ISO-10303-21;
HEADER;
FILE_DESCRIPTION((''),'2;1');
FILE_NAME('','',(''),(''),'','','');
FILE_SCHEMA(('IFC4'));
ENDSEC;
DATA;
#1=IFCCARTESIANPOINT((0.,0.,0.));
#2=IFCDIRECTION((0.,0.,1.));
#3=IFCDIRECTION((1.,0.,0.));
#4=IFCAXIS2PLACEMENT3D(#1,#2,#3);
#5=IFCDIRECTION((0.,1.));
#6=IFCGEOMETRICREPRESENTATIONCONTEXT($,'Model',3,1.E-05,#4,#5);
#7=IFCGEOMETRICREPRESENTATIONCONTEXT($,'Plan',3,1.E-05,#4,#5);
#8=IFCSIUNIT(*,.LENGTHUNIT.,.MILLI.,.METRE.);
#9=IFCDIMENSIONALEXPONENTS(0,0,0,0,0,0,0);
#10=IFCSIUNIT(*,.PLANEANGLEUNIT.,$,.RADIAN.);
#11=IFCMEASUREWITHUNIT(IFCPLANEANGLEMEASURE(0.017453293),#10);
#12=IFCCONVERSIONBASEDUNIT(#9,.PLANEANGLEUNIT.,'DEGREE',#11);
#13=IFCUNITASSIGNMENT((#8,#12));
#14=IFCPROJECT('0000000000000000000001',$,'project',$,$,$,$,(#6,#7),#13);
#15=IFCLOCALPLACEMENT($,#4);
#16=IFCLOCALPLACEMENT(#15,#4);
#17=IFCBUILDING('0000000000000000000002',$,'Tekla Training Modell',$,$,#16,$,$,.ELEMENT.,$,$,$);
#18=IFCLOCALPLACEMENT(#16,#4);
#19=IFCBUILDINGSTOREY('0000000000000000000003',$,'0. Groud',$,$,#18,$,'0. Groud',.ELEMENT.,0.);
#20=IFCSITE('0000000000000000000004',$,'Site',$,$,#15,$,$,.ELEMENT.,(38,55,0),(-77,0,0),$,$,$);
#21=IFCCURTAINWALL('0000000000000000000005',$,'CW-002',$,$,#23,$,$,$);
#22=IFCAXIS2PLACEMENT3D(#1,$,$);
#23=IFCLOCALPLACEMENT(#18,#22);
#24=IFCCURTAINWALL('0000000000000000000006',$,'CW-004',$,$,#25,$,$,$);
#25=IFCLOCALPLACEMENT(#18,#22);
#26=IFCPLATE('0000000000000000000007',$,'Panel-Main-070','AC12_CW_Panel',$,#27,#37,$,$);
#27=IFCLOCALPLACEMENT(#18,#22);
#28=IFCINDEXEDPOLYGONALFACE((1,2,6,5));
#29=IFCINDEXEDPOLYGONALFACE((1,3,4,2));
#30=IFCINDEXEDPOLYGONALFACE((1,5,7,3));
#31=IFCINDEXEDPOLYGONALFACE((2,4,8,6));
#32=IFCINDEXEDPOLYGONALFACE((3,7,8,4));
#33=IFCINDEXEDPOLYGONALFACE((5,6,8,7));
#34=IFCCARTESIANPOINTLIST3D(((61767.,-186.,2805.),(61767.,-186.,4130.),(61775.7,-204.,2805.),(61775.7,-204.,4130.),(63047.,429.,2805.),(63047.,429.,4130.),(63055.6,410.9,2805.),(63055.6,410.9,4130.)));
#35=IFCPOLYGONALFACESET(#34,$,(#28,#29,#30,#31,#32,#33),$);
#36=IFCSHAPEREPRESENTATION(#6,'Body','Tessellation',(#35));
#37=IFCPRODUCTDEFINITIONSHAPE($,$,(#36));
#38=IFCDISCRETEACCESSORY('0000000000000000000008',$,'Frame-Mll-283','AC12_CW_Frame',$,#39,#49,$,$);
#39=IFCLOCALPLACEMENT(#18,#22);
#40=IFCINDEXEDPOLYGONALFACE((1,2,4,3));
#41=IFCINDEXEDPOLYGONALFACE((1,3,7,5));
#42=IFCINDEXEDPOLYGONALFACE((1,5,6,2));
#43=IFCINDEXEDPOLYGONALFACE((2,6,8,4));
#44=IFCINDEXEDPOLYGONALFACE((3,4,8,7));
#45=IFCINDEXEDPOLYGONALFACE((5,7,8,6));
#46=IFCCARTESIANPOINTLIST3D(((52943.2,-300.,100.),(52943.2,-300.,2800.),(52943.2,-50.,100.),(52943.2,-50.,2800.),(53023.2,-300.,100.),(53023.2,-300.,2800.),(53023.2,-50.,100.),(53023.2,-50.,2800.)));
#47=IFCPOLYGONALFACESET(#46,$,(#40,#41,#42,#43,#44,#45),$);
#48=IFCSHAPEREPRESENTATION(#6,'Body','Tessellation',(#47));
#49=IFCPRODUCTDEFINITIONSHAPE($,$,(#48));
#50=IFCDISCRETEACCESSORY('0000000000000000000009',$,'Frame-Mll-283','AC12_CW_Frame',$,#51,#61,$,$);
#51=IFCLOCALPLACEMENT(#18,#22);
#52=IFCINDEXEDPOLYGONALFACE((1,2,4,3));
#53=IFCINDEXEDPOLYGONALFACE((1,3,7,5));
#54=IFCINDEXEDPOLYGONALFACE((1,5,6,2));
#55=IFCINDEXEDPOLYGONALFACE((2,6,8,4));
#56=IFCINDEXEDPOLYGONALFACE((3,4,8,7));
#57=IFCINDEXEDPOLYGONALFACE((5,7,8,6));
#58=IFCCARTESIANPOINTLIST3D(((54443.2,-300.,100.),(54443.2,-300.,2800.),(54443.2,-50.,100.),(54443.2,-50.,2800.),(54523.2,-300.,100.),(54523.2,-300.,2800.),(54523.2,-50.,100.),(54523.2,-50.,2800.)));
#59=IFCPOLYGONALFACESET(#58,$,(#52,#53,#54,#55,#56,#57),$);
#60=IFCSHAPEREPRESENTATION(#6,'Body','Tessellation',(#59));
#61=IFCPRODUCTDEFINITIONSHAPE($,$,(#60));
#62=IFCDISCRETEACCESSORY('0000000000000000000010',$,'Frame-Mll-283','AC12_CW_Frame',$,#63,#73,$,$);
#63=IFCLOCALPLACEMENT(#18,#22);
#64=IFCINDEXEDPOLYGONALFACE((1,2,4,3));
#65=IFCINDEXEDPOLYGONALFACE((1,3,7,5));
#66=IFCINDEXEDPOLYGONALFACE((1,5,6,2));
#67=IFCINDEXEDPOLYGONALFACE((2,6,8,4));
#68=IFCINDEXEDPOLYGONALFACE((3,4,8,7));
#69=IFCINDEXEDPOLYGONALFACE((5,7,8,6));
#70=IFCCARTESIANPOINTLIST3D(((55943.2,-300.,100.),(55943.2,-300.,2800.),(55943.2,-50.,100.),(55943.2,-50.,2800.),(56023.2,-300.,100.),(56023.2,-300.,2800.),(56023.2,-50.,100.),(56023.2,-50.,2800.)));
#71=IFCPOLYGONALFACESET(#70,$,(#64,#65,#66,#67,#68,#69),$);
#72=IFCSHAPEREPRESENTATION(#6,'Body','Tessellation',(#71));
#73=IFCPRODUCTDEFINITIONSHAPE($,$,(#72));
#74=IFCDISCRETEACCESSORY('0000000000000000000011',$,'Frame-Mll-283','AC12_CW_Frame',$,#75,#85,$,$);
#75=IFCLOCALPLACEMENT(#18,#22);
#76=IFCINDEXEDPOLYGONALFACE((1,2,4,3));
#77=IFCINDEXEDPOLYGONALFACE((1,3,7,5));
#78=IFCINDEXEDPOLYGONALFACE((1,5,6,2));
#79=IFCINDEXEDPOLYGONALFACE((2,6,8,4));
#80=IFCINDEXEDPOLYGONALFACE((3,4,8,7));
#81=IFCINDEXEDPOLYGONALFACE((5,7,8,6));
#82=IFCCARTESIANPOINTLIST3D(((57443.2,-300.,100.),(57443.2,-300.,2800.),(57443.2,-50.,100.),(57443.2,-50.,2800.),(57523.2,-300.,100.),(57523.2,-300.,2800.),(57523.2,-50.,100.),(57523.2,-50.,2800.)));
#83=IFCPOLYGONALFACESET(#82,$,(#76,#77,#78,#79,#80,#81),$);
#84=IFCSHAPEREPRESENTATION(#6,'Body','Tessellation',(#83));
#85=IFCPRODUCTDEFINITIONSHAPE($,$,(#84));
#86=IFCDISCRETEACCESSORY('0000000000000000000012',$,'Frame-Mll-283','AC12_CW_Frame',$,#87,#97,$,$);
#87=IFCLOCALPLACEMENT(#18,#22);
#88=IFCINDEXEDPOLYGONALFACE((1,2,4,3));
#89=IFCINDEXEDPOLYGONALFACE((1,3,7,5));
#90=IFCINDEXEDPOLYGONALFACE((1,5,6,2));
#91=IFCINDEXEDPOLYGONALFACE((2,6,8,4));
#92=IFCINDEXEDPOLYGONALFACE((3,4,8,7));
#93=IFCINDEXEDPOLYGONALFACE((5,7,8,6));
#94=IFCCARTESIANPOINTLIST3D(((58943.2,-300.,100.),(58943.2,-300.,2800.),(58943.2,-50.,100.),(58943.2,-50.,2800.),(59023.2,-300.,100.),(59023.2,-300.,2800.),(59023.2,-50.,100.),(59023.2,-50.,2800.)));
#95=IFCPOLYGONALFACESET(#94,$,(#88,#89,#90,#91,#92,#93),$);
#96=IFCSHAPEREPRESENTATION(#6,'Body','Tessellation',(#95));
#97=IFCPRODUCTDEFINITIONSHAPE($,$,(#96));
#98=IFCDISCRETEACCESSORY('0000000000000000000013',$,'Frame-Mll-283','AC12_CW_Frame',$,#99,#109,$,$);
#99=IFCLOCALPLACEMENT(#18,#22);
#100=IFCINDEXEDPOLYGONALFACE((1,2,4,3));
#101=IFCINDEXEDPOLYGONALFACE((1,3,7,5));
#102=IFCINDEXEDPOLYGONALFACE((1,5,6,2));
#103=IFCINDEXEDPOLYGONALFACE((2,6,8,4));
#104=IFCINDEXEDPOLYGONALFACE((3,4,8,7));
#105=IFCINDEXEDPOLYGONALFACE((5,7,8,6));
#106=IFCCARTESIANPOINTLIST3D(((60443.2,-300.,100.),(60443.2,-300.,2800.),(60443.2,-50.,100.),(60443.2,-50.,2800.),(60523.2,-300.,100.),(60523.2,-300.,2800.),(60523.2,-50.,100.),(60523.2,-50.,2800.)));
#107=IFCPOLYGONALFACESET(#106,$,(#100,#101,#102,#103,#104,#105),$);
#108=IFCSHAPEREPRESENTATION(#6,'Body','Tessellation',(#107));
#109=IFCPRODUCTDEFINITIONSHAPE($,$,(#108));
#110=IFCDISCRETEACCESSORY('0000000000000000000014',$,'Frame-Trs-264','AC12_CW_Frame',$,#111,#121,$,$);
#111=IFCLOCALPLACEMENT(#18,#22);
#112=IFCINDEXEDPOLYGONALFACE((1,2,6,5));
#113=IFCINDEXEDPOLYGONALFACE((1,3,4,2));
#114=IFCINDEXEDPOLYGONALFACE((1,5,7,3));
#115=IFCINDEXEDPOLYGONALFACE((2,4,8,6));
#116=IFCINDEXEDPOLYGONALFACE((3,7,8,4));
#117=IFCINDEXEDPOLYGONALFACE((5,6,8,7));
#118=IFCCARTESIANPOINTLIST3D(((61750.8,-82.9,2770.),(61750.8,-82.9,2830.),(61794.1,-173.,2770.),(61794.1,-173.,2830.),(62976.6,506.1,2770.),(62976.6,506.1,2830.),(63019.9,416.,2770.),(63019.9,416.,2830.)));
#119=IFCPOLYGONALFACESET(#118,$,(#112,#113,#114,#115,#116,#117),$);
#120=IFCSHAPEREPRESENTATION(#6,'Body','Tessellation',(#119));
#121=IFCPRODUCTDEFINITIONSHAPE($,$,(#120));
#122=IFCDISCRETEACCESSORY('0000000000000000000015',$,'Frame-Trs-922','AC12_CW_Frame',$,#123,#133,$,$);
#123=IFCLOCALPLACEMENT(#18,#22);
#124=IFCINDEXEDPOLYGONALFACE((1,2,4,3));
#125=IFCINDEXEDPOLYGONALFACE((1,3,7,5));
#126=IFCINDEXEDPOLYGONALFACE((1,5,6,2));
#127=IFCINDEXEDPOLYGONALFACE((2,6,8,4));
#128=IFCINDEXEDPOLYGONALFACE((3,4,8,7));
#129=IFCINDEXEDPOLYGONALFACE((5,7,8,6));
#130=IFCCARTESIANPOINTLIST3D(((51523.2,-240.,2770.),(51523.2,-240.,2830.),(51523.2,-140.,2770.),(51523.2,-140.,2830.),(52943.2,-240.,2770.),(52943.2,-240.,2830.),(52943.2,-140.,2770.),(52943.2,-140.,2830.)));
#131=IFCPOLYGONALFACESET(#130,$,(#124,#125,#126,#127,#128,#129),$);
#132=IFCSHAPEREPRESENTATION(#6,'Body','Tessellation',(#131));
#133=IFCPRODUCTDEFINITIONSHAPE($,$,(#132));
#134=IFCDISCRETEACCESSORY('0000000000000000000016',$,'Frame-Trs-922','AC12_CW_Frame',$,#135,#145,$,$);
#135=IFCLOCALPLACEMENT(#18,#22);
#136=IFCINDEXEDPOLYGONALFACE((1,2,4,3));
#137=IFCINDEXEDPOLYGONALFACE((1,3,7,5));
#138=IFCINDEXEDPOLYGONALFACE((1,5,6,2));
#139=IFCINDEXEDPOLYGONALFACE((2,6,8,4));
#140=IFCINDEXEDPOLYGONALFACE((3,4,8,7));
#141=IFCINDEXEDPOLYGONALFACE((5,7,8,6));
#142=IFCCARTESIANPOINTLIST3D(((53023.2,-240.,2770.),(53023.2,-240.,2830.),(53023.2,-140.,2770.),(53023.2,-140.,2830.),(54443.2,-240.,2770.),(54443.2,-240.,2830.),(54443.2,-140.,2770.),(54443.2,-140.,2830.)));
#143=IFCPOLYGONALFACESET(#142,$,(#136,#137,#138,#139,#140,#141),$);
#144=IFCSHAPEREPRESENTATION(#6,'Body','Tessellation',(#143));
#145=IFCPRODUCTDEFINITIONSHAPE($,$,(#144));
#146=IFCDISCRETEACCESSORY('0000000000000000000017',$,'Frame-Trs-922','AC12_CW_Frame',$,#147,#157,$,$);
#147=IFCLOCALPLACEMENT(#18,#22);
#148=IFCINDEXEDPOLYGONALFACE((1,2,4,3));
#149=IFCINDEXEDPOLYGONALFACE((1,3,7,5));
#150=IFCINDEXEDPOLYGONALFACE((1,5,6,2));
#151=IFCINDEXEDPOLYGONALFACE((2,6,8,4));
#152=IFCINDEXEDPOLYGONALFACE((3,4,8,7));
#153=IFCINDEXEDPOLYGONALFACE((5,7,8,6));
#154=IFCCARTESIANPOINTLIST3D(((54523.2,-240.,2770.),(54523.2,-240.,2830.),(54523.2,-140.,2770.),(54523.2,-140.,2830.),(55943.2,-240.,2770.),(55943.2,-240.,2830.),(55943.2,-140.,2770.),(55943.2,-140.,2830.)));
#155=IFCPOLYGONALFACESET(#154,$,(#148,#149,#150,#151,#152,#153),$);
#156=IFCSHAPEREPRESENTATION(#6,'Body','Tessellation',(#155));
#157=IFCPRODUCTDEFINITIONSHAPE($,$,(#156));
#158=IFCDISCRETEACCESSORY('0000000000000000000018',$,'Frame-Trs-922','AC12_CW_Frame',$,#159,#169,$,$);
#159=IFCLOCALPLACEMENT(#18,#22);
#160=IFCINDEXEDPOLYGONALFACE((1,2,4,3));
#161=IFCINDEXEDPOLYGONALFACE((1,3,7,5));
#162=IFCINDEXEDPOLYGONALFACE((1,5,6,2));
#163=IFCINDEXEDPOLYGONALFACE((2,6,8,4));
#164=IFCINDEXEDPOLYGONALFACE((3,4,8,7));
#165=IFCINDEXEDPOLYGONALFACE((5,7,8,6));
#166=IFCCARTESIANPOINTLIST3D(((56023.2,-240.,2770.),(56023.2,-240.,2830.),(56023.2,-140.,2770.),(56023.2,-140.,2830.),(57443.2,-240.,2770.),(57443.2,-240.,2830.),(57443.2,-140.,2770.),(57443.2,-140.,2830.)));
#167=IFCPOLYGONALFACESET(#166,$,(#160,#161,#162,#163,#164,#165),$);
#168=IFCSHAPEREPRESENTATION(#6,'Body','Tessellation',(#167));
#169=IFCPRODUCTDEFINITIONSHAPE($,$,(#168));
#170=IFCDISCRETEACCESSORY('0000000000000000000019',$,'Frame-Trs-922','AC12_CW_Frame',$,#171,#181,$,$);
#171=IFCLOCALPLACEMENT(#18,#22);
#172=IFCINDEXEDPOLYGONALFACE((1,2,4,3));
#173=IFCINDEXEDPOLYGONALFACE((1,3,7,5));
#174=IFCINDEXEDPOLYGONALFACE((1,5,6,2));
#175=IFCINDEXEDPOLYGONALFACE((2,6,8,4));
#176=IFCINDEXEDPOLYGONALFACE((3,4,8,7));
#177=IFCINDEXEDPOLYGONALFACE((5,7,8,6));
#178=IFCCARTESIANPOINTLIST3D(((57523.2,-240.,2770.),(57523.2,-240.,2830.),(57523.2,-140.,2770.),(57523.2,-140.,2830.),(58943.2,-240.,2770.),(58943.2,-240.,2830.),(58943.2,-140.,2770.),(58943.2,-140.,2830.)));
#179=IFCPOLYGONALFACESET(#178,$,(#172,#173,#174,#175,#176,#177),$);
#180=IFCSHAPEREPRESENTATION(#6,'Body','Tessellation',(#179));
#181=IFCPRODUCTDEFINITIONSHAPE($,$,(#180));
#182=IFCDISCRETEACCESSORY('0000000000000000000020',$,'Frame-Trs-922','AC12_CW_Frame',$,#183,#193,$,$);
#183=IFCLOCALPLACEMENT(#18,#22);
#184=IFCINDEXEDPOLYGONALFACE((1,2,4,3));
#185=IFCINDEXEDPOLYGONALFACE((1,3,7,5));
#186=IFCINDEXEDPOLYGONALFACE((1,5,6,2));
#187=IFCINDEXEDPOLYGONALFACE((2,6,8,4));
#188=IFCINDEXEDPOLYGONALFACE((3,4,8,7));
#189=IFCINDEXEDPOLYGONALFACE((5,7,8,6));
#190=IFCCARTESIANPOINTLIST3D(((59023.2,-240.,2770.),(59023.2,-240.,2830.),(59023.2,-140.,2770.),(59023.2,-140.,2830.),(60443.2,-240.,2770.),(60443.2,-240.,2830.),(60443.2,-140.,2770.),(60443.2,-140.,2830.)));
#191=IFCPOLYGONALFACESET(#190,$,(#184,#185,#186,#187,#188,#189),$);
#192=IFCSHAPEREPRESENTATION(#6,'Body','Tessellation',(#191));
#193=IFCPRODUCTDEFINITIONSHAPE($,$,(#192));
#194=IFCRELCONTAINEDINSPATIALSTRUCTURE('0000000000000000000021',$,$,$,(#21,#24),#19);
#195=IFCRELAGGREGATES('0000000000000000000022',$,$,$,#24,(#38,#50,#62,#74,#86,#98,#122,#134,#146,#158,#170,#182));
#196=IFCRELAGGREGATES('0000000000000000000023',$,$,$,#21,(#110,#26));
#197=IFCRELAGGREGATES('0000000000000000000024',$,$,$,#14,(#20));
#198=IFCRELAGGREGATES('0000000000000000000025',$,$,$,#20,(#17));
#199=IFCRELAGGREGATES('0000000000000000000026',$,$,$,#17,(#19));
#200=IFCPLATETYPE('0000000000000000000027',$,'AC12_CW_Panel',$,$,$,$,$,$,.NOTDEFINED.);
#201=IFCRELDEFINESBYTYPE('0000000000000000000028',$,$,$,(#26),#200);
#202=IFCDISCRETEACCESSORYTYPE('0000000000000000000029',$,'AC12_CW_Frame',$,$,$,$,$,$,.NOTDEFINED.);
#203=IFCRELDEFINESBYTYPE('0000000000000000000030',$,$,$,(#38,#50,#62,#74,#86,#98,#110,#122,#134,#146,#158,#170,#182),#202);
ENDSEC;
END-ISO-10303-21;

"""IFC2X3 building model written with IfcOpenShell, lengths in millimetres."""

from ifc_helpers import new_model, entity, si_unit, converted_unit, direction, frame, origin_with_axes, place, context, project, spatial, polyline, outline, extrude, source, transform, mapped, type_object, element, aggregate, save


model = new_model("IFC2X3")

# Units and contexts
model_context = context("Model", 3, precision=1e-05, world=origin_with_axes(), true_north=direction((0.0, 1.0)))
plan_context = context("Plan", 3, precision=1e-05, world=origin_with_axes(), true_north=direction((0.0, 1.0)))
ifc_project = project(units=[si_unit("LENGTHUNIT", "METRE", prefix="MILLI"), converted_unit("PLANEANGLEUNIT", "DEGREE", entity("IfcPlaneAngleMeasure", 0.017453293), si_unit("PLANEANGLEUNIT", "RADIAN"), dimensions=[0, 0, 0, 0, 0, 0, 0])], contexts=[model_context, plan_context])

# Site, building, storey
site_placement = place(None, origin_with_axes())
site = spatial("IfcSite", under=ifc_project, at=site_placement, Name="Site", CompositionType="ELEMENT", RefLatitude=(38, 55, 0), RefLongitude=(-77, 0, 0))
building_placement = place(site_placement, origin_with_axes())
building = spatial("IfcBuilding", under=site, at=building_placement, Name="Tekla Training Modell", CompositionType="ELEMENT")
storey_placement = place(building_placement, origin_with_axes())
storey = spatial("IfcBuildingStorey", under=building, at=storey_placement, Name="0. Groud", LongName="0. Groud", CompositionType="ELEMENT", Elevation=0.0)

# Curtain wall
curtain_wall_1_placement = place(storey_placement, frame((61708.3, -225.3, 0.0), z_axis=(0.0, 0.0, 1.0), x_axis=(0.901357, 0.433078, 0.0)))
curtain_wall_1 = element("IfcCurtainWall", 1, at=curtain_wall_1_placement, inside=storey, Name="CW-002")
plate_type = type_object("IfcPlateType", Name="AC12_CW_Panel", PredefinedType="NOTDEFINED")

# Curtain wall
curtain_wall_2_placement = place(storey_placement, frame((3483.2, -250.0, 0.0), z_axis=(0.0, 0.0, 1.0), x_axis=(1.0, 0.0, 0.0)))
curtain_wall_2 = element("IfcCurtainWall", 2, at=curtain_wall_2_placement, inside=storey, Name="CW-004")

# Plate
shared_shape_1 = source(origin_with_axes(), model_context, "Body", "SweptSolid", [
    extrude(outline(polyline([(0.0, 0.0), (1420.0, 0.0), (1420.0, -20.0), (0.0, -20.0), (0.0, 0.0)])), origin_with_axes(), (0.0, 0.0, 1.0), 1325.0),
])
plate_1_placement = place(storey_placement, frame((61767.0, -186.0, 2805.0), z_axis=(0.0, 0.0, 1.0), x_axis=(0.901357, 0.433078, 0.0)))
plate_1 = element("IfcPlate", 3, at=plate_1_placement, type_object=plate_type, Name="Panel-Main-070", Description="AC12_CW_Panel", context=model_context, shape_type="MappedRepresentation", body=[
    mapped(shared_shape_1, transform((0.0, 0.0, 0.0), scale=1.0)),
])

# Discrete accessories
discrete_accessory_type = type_object("IfcDiscreteAccessoryType", Name="AC12_CW_Frame")
shared_shape_2 = source(origin_with_axes(), model_context, "Body", "SweptSolid", [
    extrude(outline(polyline([(0.0, 0.0), (250.0, 0.0), (250.0, -2700.0), (0.0, -2700.0), (0.0, 0.0)])), origin_with_axes(), (0.0, 0.0, 1.0), 80.0),
])
discrete_accessory_1_placement = place(storey_placement, frame((52943.2, -50.0, 100.0), z_axis=(1.0, 0.0, 0.0), x_axis=(0.0, -1.0, 0.0)))
discrete_accessory_1 = element("IfcDiscreteAccessory", 4, at=discrete_accessory_1_placement, type_object=discrete_accessory_type, Name="Frame-Mll-283", Description="AC12_CW_Frame", context=model_context, shape_type="MappedRepresentation", body=[
    mapped(shared_shape_2, transform((0.0, 0.0, 0.0), scale=1.0)),
])
discrete_accessory_2_placement = place(storey_placement, frame((54443.2, -50.0, 100.0), z_axis=(1.0, 0.0, 0.0), x_axis=(0.0, -1.0, 0.0)))
discrete_accessory_2 = element("IfcDiscreteAccessory", 5, at=discrete_accessory_2_placement, type_object=discrete_accessory_type, Name="Frame-Mll-283", Description="AC12_CW_Frame", context=model_context, shape_type="MappedRepresentation", body=[
    mapped(shared_shape_2, transform((0.0, 0.0, 0.0), scale=1.0)),
])
discrete_accessory_3_placement = place(storey_placement, frame((55943.2, -50.0, 100.0), z_axis=(1.0, 0.0, 0.0), x_axis=(0.0, -1.0, 0.0)))
discrete_accessory_3 = element("IfcDiscreteAccessory", 6, at=discrete_accessory_3_placement, type_object=discrete_accessory_type, Name="Frame-Mll-283", Description="AC12_CW_Frame", context=model_context, shape_type="MappedRepresentation", body=[
    mapped(shared_shape_2, transform((0.0, 0.0, 0.0), scale=1.0)),
])
discrete_accessory_4_placement = place(storey_placement, frame((57443.2, -50.0, 100.0), z_axis=(1.0, 0.0, 0.0), x_axis=(0.0, -1.0, 0.0)))
discrete_accessory_4 = element("IfcDiscreteAccessory", 7, at=discrete_accessory_4_placement, type_object=discrete_accessory_type, Name="Frame-Mll-283", Description="AC12_CW_Frame", context=model_context, shape_type="MappedRepresentation", body=[
    mapped(shared_shape_2, transform((0.0, 0.0, 0.0), scale=1.0)),
])
discrete_accessory_5_placement = place(storey_placement, frame((58943.2, -50.0, 100.0), z_axis=(1.0, 0.0, 0.0), x_axis=(0.0, -1.0, 0.0)))
discrete_accessory_5 = element("IfcDiscreteAccessory", 8, at=discrete_accessory_5_placement, type_object=discrete_accessory_type, Name="Frame-Mll-283", Description="AC12_CW_Frame", context=model_context, shape_type="MappedRepresentation", body=[
    mapped(shared_shape_2, transform((0.0, 0.0, 0.0), scale=1.0)),
])
discrete_accessory_6_placement = place(storey_placement, frame((60443.2, -50.0, 100.0), z_axis=(1.0, 0.0, 0.0), x_axis=(0.0, -1.0, 0.0)))
discrete_accessory_6 = element("IfcDiscreteAccessory", 9, at=discrete_accessory_6_placement, type_object=discrete_accessory_type, Name="Frame-Mll-283", Description="AC12_CW_Frame", context=model_context, shape_type="MappedRepresentation", body=[
    mapped(shared_shape_2, transform((0.0, 0.0, 0.0), scale=1.0)),
])
shared_shape_3 = source(origin_with_axes(), model_context, "Body", "SweptSolid", [
    extrude(outline(polyline([(0.0, 0.0), (100.0, 0.0), (100.0, -1360.0), (0.0, -1360.0), (0.0, 0.0)])), origin_with_axes(), (0.0, 0.0, 1.0), 60.0),
])
discrete_accessory_7_placement = place(storey_placement, frame((61750.8, -82.9, 2830.0), z_axis=(0.0, 0.0, -1.0), x_axis=(0.433078, -0.901357, 0.0)))
discrete_accessory_7 = element("IfcDiscreteAccessory", 10, at=discrete_accessory_7_placement, type_object=discrete_accessory_type, Name="Frame-Trs-264", Description="AC12_CW_Frame", context=model_context, shape_type="MappedRepresentation", body=[
    mapped(shared_shape_3, transform((0.0, 0.0, 0.0), scale=1.0)),
])
shared_shape_4 = source(origin_with_axes(), model_context, "Body", "SweptSolid", [
    extrude(outline(polyline([(0.0, 0.0), (100.0, 0.0), (100.0, -1420.0), (0.0, -1420.0), (0.0, 0.0)])), origin_with_axes(), (0.0, 0.0, 1.0), 60.0),
])
discrete_accessory_8_placement = place(storey_placement, frame((51523.2, -140.0, 2830.0), z_axis=(0.0, 0.0, -1.0), x_axis=(0.0, -1.0, 0.0)))
discrete_accessory_8 = element("IfcDiscreteAccessory", 11, at=discrete_accessory_8_placement, type_object=discrete_accessory_type, Name="Frame-Trs-922", Description="AC12_CW_Frame", context=model_context, shape_type="MappedRepresentation", body=[
    mapped(shared_shape_4, transform((0.0, 0.0, 0.0), scale=1.0)),
])
discrete_accessory_9_placement = place(storey_placement, frame((53023.2, -140.0, 2830.0), z_axis=(0.0, 0.0, -1.0), x_axis=(0.0, -1.0, 0.0)))
discrete_accessory_9 = element("IfcDiscreteAccessory", 12, at=discrete_accessory_9_placement, type_object=discrete_accessory_type, Name="Frame-Trs-922", Description="AC12_CW_Frame", context=model_context, shape_type="MappedRepresentation", body=[
    mapped(shared_shape_4, transform((0.0, 0.0, 0.0), scale=1.0)),
])
discrete_accessory_10_placement = place(storey_placement, frame((54523.2, -140.0, 2830.0), z_axis=(0.0, 0.0, -1.0), x_axis=(0.0, -1.0, 0.0)))
discrete_accessory_10 = element("IfcDiscreteAccessory", 13, at=discrete_accessory_10_placement, type_object=discrete_accessory_type, Name="Frame-Trs-922", Description="AC12_CW_Frame", context=model_context, shape_type="MappedRepresentation", body=[
    mapped(shared_shape_4, transform((0.0, 0.0, 0.0), scale=1.0)),
])
discrete_accessory_11_placement = place(storey_placement, frame((56023.2, -140.0, 2830.0), z_axis=(0.0, 0.0, -1.0), x_axis=(0.0, -1.0, 0.0)))
discrete_accessory_11 = element("IfcDiscreteAccessory", 14, at=discrete_accessory_11_placement, type_object=discrete_accessory_type, Name="Frame-Trs-922", Description="AC12_CW_Frame", context=model_context, shape_type="MappedRepresentation", body=[
    mapped(shared_shape_4, transform((0.0, 0.0, 0.0), scale=1.0)),
])
discrete_accessory_12_placement = place(storey_placement, frame((57523.2, -140.0, 2830.0), z_axis=(0.0, 0.0, -1.0), x_axis=(0.0, -1.0, 0.0)))
discrete_accessory_12 = element("IfcDiscreteAccessory", 15, at=discrete_accessory_12_placement, type_object=discrete_accessory_type, Name="Frame-Trs-922", Description="AC12_CW_Frame", context=model_context, shape_type="MappedRepresentation", body=[
    mapped(shared_shape_4, transform((0.0, 0.0, 0.0), scale=1.0)),
])
discrete_accessory_13_placement = place(storey_placement, frame((59023.2, -140.0, 2830.0), z_axis=(0.0, 0.0, -1.0), x_axis=(0.0, -1.0, 0.0)))
discrete_accessory_13 = element("IfcDiscreteAccessory", 16, at=discrete_accessory_13_placement, type_object=discrete_accessory_type, Name="Frame-Trs-922", Description="AC12_CW_Frame", context=model_context, shape_type="MappedRepresentation", body=[
    mapped(shared_shape_4, transform((0.0, 0.0, 0.0), scale=1.0)),
])
aggregate(curtain_wall_2, [discrete_accessory_1, discrete_accessory_2, discrete_accessory_3, discrete_accessory_4, discrete_accessory_5, discrete_accessory_6, discrete_accessory_8, discrete_accessory_9, discrete_accessory_10, discrete_accessory_11, discrete_accessory_12, discrete_accessory_13])
aggregate(curtain_wall_1, [discrete_accessory_7, plate_1])

save(model, "model.ifc")
